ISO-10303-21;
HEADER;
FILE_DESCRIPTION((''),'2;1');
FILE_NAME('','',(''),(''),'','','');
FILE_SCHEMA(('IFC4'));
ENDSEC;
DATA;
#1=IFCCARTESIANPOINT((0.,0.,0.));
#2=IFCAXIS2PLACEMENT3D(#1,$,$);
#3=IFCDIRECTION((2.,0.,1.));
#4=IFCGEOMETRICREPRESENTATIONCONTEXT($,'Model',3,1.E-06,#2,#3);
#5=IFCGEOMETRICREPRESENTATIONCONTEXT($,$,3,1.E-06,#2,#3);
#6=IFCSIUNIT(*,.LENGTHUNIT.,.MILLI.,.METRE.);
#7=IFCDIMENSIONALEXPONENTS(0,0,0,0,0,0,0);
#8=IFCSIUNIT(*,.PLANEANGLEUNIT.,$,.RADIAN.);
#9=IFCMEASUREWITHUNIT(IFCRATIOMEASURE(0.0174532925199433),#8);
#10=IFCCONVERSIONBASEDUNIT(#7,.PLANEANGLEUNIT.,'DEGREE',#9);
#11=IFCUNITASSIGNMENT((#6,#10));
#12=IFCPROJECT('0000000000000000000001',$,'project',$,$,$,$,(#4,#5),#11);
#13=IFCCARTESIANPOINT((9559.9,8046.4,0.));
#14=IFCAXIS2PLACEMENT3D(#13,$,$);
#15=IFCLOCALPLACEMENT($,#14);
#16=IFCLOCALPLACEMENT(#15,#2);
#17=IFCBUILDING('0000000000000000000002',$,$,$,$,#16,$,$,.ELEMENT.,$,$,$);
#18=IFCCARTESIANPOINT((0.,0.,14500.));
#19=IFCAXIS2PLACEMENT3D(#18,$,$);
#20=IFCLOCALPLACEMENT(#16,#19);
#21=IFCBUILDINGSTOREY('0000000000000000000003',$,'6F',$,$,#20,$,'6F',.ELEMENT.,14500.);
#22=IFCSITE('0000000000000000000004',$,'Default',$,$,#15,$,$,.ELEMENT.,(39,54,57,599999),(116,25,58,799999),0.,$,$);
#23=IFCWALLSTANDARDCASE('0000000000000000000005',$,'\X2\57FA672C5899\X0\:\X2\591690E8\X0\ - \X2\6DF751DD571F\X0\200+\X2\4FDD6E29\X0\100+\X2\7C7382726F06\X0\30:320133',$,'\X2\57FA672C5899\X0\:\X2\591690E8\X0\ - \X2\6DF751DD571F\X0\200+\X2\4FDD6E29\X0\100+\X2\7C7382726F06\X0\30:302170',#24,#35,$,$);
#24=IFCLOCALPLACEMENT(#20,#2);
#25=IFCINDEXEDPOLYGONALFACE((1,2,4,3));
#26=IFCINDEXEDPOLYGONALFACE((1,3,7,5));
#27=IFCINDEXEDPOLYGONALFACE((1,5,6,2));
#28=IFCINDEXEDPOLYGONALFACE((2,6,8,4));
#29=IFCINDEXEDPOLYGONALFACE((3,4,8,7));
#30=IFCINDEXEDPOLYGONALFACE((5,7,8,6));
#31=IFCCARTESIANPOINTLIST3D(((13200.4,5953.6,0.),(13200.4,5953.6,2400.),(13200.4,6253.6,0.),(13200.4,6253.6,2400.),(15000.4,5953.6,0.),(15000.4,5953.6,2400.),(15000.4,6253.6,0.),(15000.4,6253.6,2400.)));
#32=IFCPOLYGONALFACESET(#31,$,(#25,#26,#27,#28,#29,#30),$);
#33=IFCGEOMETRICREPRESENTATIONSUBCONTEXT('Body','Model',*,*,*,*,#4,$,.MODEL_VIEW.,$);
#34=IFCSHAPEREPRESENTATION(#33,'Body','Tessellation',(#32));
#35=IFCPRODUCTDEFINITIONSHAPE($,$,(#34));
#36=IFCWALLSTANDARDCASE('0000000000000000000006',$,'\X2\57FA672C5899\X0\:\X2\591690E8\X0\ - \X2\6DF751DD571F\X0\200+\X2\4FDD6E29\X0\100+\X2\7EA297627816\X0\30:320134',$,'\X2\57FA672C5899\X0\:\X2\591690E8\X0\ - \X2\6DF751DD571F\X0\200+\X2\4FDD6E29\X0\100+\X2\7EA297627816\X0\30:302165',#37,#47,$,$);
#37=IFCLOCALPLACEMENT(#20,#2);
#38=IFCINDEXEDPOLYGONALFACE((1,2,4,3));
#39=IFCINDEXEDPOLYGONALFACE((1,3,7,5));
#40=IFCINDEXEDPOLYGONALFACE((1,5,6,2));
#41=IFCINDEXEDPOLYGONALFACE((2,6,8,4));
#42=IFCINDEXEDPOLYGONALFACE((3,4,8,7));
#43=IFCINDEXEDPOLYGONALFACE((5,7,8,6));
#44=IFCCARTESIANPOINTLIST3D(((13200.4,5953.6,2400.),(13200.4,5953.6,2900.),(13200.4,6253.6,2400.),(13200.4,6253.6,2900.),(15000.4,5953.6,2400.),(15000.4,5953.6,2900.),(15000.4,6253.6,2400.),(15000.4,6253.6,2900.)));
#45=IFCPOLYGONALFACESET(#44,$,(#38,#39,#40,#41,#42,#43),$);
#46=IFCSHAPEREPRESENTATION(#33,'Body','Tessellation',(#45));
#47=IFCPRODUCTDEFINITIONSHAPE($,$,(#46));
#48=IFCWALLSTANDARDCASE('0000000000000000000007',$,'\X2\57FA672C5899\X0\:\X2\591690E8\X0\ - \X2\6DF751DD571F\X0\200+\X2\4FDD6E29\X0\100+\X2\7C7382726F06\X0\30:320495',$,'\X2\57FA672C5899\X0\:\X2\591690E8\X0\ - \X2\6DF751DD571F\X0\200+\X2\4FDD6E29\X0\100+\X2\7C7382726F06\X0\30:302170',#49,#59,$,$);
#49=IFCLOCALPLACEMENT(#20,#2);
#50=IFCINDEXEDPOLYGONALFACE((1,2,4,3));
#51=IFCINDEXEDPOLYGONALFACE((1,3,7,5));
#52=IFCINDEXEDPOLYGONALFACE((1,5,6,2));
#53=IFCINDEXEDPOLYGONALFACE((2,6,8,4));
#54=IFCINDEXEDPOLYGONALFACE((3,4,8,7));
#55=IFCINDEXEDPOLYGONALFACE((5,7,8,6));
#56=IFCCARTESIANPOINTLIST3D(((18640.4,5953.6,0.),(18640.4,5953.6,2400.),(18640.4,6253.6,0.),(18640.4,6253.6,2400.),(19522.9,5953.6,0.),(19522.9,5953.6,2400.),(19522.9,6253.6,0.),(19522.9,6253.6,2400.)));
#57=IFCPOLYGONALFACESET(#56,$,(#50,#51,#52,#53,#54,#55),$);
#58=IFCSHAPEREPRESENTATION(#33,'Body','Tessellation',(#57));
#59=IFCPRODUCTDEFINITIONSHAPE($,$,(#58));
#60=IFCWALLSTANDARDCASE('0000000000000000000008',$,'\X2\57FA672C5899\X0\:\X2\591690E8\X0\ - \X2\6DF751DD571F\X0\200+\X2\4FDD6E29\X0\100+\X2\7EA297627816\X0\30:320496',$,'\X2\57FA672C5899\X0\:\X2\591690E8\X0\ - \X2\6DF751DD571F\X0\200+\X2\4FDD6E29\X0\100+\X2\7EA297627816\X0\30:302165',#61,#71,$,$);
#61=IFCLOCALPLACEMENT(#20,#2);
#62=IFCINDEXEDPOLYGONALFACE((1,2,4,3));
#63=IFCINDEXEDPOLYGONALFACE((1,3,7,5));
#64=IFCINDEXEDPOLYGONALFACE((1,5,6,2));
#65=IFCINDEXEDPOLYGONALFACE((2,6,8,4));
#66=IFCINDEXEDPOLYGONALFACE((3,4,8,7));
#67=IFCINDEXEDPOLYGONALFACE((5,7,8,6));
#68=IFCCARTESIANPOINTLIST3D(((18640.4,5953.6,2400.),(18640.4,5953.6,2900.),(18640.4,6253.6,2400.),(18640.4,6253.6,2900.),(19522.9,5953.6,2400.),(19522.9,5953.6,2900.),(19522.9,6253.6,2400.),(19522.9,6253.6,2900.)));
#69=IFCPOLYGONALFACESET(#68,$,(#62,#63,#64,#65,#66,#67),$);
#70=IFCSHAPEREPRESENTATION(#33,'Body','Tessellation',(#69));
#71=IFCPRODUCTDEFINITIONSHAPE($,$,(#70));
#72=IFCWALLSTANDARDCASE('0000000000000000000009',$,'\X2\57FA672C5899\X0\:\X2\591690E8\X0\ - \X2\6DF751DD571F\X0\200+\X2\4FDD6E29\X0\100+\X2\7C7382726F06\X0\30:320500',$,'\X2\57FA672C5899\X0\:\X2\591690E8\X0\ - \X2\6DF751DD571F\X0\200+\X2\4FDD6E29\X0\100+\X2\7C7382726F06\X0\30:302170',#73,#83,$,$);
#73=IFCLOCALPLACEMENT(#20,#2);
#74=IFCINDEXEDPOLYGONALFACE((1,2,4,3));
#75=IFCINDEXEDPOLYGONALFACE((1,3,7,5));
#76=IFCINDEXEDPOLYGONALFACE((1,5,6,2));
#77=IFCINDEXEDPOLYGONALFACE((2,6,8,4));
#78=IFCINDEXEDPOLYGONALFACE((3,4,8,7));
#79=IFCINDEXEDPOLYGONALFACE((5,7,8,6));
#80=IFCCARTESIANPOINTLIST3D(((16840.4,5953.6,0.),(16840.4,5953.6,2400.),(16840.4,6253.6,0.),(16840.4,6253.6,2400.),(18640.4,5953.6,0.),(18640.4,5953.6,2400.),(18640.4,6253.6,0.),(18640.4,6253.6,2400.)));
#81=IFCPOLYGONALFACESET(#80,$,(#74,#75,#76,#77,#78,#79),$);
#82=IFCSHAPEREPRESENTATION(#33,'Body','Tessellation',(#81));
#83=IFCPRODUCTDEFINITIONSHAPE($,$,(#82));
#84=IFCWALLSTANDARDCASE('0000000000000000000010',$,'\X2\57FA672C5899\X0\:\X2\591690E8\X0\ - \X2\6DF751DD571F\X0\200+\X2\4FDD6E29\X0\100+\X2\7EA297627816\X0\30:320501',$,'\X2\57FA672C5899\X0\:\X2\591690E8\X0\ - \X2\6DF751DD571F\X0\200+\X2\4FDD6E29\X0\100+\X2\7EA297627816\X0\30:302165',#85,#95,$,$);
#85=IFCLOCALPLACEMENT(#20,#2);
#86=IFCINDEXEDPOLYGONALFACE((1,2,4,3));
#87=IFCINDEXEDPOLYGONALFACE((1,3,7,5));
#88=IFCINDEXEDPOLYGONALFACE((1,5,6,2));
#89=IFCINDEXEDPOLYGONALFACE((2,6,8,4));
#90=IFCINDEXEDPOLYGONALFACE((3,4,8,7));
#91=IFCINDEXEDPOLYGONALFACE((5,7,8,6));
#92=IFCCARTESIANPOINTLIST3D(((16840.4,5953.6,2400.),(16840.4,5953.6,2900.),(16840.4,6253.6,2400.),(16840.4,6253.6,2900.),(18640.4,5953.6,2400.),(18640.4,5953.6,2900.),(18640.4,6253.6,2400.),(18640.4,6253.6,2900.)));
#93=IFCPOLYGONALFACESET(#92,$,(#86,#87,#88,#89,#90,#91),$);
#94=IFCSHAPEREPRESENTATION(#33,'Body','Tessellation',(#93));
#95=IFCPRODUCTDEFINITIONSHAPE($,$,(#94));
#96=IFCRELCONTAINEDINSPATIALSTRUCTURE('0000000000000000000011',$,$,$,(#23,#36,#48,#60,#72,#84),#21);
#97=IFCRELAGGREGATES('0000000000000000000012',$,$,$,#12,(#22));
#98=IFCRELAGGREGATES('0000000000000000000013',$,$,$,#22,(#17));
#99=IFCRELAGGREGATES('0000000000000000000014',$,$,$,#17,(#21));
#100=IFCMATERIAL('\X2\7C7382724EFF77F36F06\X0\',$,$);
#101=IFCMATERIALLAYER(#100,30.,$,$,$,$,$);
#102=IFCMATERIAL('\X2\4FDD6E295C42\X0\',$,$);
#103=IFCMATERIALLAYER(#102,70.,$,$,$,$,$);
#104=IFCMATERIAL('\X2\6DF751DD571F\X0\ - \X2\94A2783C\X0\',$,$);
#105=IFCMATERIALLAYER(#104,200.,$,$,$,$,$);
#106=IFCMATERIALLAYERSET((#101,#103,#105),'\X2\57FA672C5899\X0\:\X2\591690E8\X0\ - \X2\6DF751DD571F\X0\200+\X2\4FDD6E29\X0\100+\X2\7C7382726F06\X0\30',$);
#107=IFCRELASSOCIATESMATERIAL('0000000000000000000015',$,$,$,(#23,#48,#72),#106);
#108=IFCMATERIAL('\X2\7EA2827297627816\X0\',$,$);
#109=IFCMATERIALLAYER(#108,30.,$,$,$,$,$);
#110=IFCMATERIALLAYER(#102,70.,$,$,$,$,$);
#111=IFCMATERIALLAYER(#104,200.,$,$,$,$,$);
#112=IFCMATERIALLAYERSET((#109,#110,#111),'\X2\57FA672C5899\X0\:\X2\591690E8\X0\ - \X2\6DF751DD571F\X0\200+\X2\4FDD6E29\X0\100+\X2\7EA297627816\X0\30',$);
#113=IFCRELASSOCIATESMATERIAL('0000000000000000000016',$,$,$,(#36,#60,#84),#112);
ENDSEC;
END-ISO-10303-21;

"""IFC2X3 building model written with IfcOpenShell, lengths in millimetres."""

from ifc_helpers import new_model, entity, si_unit, converted_unit, direction, frame, frame_2d, origin, place, context, subcontext, project, spatial, rectangle, extrude, material, layer, layer_set, layer_usage, element, save


model = new_model("IFC2X3")

# Units and contexts
model_context = context("Model", 3, precision=1e-06, world=origin(), true_north=direction((2.0, 0.0, 1.0)))
context_of_model = context(None, 3, precision=1e-06, world=origin(), true_north=direction((2.0, 0.0, 1.0)))
body_context = subcontext(model_context, "Body", "Model", "MODEL_VIEW")
ifc_project = project(units=[si_unit("LENGTHUNIT", "METRE", prefix="MILLI"), converted_unit("PLANEANGLEUNIT", "DEGREE", entity("IfcRatioMeasure", 0.0174532925199433), si_unit("PLANEANGLEUNIT", "RADIAN"), dimensions=[0, 0, 0, 0, 0, 0, 0])], contexts=[model_context, context_of_model])

# Site, building, storey
site_placement = place(None, frame((9559.9, 8046.4, 0.0)))
site = spatial("IfcSite", under=ifc_project, at=site_placement, Name="Default", CompositionType="ELEMENT", RefLatitude=(39, 54, 57, 599999), RefLongitude=(116, 25, 58, 799999), RefElevation=0.0)
building_placement = place(site_placement, origin())
building = spatial("IfcBuilding", under=site, at=building_placement, CompositionType="ELEMENT")
storey_placement = place(building_placement, frame((0.0, 0.0, 14500.0)))
storey = spatial("IfcBuildingStorey", under=building, at=storey_placement, Name="6F", LongName="6F", CompositionType="ELEMENT", Elevation=14500.0)

# Shared definitions
ifc_material_1 = material(Name="红色面砖")
ifc_layer_1 = layer(ifc_material_1, 30.0)
ifc_material_2 = material(Name="保温层")
ifc_layer_2 = layer(ifc_material_2, 70.0)
ifc_material_3 = material(Name="混凝土 - 钢砼")
ifc_layer_3 = layer(ifc_material_3, 200.0)
ifc_layer_set_1 = layer_set([ifc_layer_1, ifc_layer_2, ifc_layer_3], Name="基本墙:外部 - 混凝土200+保温100+红面砖30")

# Walls
ifc_material_4 = material(Name="米色仿石漆")
ifc_layer_4 = layer(ifc_material_4, 30.0)
ifc_layer_5 = layer(ifc_material_2, 70.0)
ifc_layer_6 = layer(ifc_material_3, 200.0)
ifc_layer_set_2 = layer_set([ifc_layer_4, ifc_layer_5, ifc_layer_6], Name="基本墙:外部 - 混凝土200+保温100+米色漆30")
ifc_layer_usage_1 = layer_usage(ifc_layer_set_2, "AXIS2", "POSITIVE", -150.0)
wall_1_placement = place(storey_placement, frame((15000.4, 6103.6, 0.0), z_axis=(0.0, 0.0, 1.0), x_axis=(-1.0, 0.0, 0.0)))
element("IfcWallStandardCase", 1, at=wall_1_placement, inside=storey, material=ifc_layer_usage_1, Name="基本墙:外部 - 混凝土200+保温100+米色漆30:320133", ObjectType="基本墙:外部 - 混凝土200+保温100+米色漆30:302170", context=body_context, shape_type="SweptSolid", body=[
    extrude(rectangle(XDim=1800.0, YDim=300.0, at=frame_2d((900.0, 0.0), x_axis=(-1.0, 0.0))), origin(), (0.0, 0.0, 1.0), 2400.0),
])
ifc_layer_usage_2 = layer_usage(ifc_layer_set_1, "AXIS2", "POSITIVE", -150.0)
wall_2_placement = place(storey_placement, frame((15000.4, 6103.6, 2400.0), z_axis=(0.0, 0.0, 1.0), x_axis=(-1.0, 0.0, 0.0)))
element("IfcWallStandardCase", 2, at=wall_2_placement, inside=storey, material=ifc_layer_usage_2, Name="基本墙:外部 - 混凝土200+保温100+红面砖30:320134", ObjectType="基本墙:外部 - 混凝土200+保温100+红面砖30:302165", context=body_context, shape_type="SweptSolid", body=[
    extrude(rectangle(XDim=1800.0, YDim=300.0, at=frame_2d((900.0, 0.0), x_axis=(-1.0, 0.0))), origin(), (0.0, 0.0, 1.0), 500.0),
])

# Walls
ifc_layer_usage_3 = layer_usage(ifc_layer_set_2, "AXIS2", "NEGATIVE", 150.0)
wall_3_placement = place(storey_placement, frame((18640.4, 6103.6, 0.0)))
element("IfcWallStandardCase", 3, at=wall_3_placement, inside=storey, material=ifc_layer_usage_3, Name="基本墙:外部 - 混凝土200+保温100+米色漆30:320495", ObjectType="基本墙:外部 - 混凝土200+保温100+米色漆30:302170", context=body_context, shape_type="SweptSolid", body=[
    extrude(rectangle(XDim=882.5, YDim=300.0, at=frame_2d((441.3, 0.0), x_axis=(-1.0, 0.0))), origin(), (0.0, 0.0, 1.0), 2400.0),
])
ifc_layer_usage_4 = layer_usage(ifc_layer_set_1, "AXIS2", "NEGATIVE", 150.0)
wall_4_placement = place(storey_placement, frame((18640.4, 6103.6, 2400.0)))
element("IfcWallStandardCase", 4, at=wall_4_placement, inside=storey, material=ifc_layer_usage_4, Name="基本墙:外部 - 混凝土200+保温100+红面砖30:320496", ObjectType="基本墙:外部 - 混凝土200+保温100+红面砖30:302165", context=body_context, shape_type="SweptSolid", body=[
    extrude(rectangle(XDim=882.5, YDim=300.0, at=frame_2d((441.3, 0.0), x_axis=(-1.0, 0.0))), origin(), (0.0, 0.0, 1.0), 500.0),
])
ifc_layer_usage_5 = layer_usage(ifc_layer_set_2, "AXIS2", "NEGATIVE", 150.0)
wall_5_placement = place(storey_placement, frame((16840.4, 6103.6, 0.0)))
element("IfcWallStandardCase", 5, at=wall_5_placement, inside=storey, material=ifc_layer_usage_5, Name="基本墙:外部 - 混凝土200+保温100+米色漆30:320500", ObjectType="基本墙:外部 - 混凝土200+保温100+米色漆30:302170", context=body_context, shape_type="SweptSolid", body=[
    extrude(rectangle(XDim=1800.0, YDim=300.0, at=frame_2d((900.0, 0.0), x_axis=(-1.0, 0.0))), origin(), (0.0, 0.0, 1.0), 2400.0),
])
ifc_layer_usage_6 = layer_usage(ifc_layer_set_1, "AXIS2", "NEGATIVE", 150.0)
wall_6_placement = place(storey_placement, frame((16840.4, 6103.6, 2400.0)))
element("IfcWallStandardCase", 6, at=wall_6_placement, inside=storey, material=ifc_layer_usage_6, Name="基本墙:外部 - 混凝土200+保温100+红面砖30:320501", ObjectType="基本墙:外部 - 混凝土200+保温100+红面砖30:302165", context=body_context, shape_type="SweptSolid", body=[
    extrude(rectangle(XDim=1800.0, YDim=300.0, at=frame_2d((900.0, 0.0), x_axis=(-1.0, 0.0))), origin(), (0.0, 0.0, 1.0), 500.0),
])

save(model, "model.ifc")
